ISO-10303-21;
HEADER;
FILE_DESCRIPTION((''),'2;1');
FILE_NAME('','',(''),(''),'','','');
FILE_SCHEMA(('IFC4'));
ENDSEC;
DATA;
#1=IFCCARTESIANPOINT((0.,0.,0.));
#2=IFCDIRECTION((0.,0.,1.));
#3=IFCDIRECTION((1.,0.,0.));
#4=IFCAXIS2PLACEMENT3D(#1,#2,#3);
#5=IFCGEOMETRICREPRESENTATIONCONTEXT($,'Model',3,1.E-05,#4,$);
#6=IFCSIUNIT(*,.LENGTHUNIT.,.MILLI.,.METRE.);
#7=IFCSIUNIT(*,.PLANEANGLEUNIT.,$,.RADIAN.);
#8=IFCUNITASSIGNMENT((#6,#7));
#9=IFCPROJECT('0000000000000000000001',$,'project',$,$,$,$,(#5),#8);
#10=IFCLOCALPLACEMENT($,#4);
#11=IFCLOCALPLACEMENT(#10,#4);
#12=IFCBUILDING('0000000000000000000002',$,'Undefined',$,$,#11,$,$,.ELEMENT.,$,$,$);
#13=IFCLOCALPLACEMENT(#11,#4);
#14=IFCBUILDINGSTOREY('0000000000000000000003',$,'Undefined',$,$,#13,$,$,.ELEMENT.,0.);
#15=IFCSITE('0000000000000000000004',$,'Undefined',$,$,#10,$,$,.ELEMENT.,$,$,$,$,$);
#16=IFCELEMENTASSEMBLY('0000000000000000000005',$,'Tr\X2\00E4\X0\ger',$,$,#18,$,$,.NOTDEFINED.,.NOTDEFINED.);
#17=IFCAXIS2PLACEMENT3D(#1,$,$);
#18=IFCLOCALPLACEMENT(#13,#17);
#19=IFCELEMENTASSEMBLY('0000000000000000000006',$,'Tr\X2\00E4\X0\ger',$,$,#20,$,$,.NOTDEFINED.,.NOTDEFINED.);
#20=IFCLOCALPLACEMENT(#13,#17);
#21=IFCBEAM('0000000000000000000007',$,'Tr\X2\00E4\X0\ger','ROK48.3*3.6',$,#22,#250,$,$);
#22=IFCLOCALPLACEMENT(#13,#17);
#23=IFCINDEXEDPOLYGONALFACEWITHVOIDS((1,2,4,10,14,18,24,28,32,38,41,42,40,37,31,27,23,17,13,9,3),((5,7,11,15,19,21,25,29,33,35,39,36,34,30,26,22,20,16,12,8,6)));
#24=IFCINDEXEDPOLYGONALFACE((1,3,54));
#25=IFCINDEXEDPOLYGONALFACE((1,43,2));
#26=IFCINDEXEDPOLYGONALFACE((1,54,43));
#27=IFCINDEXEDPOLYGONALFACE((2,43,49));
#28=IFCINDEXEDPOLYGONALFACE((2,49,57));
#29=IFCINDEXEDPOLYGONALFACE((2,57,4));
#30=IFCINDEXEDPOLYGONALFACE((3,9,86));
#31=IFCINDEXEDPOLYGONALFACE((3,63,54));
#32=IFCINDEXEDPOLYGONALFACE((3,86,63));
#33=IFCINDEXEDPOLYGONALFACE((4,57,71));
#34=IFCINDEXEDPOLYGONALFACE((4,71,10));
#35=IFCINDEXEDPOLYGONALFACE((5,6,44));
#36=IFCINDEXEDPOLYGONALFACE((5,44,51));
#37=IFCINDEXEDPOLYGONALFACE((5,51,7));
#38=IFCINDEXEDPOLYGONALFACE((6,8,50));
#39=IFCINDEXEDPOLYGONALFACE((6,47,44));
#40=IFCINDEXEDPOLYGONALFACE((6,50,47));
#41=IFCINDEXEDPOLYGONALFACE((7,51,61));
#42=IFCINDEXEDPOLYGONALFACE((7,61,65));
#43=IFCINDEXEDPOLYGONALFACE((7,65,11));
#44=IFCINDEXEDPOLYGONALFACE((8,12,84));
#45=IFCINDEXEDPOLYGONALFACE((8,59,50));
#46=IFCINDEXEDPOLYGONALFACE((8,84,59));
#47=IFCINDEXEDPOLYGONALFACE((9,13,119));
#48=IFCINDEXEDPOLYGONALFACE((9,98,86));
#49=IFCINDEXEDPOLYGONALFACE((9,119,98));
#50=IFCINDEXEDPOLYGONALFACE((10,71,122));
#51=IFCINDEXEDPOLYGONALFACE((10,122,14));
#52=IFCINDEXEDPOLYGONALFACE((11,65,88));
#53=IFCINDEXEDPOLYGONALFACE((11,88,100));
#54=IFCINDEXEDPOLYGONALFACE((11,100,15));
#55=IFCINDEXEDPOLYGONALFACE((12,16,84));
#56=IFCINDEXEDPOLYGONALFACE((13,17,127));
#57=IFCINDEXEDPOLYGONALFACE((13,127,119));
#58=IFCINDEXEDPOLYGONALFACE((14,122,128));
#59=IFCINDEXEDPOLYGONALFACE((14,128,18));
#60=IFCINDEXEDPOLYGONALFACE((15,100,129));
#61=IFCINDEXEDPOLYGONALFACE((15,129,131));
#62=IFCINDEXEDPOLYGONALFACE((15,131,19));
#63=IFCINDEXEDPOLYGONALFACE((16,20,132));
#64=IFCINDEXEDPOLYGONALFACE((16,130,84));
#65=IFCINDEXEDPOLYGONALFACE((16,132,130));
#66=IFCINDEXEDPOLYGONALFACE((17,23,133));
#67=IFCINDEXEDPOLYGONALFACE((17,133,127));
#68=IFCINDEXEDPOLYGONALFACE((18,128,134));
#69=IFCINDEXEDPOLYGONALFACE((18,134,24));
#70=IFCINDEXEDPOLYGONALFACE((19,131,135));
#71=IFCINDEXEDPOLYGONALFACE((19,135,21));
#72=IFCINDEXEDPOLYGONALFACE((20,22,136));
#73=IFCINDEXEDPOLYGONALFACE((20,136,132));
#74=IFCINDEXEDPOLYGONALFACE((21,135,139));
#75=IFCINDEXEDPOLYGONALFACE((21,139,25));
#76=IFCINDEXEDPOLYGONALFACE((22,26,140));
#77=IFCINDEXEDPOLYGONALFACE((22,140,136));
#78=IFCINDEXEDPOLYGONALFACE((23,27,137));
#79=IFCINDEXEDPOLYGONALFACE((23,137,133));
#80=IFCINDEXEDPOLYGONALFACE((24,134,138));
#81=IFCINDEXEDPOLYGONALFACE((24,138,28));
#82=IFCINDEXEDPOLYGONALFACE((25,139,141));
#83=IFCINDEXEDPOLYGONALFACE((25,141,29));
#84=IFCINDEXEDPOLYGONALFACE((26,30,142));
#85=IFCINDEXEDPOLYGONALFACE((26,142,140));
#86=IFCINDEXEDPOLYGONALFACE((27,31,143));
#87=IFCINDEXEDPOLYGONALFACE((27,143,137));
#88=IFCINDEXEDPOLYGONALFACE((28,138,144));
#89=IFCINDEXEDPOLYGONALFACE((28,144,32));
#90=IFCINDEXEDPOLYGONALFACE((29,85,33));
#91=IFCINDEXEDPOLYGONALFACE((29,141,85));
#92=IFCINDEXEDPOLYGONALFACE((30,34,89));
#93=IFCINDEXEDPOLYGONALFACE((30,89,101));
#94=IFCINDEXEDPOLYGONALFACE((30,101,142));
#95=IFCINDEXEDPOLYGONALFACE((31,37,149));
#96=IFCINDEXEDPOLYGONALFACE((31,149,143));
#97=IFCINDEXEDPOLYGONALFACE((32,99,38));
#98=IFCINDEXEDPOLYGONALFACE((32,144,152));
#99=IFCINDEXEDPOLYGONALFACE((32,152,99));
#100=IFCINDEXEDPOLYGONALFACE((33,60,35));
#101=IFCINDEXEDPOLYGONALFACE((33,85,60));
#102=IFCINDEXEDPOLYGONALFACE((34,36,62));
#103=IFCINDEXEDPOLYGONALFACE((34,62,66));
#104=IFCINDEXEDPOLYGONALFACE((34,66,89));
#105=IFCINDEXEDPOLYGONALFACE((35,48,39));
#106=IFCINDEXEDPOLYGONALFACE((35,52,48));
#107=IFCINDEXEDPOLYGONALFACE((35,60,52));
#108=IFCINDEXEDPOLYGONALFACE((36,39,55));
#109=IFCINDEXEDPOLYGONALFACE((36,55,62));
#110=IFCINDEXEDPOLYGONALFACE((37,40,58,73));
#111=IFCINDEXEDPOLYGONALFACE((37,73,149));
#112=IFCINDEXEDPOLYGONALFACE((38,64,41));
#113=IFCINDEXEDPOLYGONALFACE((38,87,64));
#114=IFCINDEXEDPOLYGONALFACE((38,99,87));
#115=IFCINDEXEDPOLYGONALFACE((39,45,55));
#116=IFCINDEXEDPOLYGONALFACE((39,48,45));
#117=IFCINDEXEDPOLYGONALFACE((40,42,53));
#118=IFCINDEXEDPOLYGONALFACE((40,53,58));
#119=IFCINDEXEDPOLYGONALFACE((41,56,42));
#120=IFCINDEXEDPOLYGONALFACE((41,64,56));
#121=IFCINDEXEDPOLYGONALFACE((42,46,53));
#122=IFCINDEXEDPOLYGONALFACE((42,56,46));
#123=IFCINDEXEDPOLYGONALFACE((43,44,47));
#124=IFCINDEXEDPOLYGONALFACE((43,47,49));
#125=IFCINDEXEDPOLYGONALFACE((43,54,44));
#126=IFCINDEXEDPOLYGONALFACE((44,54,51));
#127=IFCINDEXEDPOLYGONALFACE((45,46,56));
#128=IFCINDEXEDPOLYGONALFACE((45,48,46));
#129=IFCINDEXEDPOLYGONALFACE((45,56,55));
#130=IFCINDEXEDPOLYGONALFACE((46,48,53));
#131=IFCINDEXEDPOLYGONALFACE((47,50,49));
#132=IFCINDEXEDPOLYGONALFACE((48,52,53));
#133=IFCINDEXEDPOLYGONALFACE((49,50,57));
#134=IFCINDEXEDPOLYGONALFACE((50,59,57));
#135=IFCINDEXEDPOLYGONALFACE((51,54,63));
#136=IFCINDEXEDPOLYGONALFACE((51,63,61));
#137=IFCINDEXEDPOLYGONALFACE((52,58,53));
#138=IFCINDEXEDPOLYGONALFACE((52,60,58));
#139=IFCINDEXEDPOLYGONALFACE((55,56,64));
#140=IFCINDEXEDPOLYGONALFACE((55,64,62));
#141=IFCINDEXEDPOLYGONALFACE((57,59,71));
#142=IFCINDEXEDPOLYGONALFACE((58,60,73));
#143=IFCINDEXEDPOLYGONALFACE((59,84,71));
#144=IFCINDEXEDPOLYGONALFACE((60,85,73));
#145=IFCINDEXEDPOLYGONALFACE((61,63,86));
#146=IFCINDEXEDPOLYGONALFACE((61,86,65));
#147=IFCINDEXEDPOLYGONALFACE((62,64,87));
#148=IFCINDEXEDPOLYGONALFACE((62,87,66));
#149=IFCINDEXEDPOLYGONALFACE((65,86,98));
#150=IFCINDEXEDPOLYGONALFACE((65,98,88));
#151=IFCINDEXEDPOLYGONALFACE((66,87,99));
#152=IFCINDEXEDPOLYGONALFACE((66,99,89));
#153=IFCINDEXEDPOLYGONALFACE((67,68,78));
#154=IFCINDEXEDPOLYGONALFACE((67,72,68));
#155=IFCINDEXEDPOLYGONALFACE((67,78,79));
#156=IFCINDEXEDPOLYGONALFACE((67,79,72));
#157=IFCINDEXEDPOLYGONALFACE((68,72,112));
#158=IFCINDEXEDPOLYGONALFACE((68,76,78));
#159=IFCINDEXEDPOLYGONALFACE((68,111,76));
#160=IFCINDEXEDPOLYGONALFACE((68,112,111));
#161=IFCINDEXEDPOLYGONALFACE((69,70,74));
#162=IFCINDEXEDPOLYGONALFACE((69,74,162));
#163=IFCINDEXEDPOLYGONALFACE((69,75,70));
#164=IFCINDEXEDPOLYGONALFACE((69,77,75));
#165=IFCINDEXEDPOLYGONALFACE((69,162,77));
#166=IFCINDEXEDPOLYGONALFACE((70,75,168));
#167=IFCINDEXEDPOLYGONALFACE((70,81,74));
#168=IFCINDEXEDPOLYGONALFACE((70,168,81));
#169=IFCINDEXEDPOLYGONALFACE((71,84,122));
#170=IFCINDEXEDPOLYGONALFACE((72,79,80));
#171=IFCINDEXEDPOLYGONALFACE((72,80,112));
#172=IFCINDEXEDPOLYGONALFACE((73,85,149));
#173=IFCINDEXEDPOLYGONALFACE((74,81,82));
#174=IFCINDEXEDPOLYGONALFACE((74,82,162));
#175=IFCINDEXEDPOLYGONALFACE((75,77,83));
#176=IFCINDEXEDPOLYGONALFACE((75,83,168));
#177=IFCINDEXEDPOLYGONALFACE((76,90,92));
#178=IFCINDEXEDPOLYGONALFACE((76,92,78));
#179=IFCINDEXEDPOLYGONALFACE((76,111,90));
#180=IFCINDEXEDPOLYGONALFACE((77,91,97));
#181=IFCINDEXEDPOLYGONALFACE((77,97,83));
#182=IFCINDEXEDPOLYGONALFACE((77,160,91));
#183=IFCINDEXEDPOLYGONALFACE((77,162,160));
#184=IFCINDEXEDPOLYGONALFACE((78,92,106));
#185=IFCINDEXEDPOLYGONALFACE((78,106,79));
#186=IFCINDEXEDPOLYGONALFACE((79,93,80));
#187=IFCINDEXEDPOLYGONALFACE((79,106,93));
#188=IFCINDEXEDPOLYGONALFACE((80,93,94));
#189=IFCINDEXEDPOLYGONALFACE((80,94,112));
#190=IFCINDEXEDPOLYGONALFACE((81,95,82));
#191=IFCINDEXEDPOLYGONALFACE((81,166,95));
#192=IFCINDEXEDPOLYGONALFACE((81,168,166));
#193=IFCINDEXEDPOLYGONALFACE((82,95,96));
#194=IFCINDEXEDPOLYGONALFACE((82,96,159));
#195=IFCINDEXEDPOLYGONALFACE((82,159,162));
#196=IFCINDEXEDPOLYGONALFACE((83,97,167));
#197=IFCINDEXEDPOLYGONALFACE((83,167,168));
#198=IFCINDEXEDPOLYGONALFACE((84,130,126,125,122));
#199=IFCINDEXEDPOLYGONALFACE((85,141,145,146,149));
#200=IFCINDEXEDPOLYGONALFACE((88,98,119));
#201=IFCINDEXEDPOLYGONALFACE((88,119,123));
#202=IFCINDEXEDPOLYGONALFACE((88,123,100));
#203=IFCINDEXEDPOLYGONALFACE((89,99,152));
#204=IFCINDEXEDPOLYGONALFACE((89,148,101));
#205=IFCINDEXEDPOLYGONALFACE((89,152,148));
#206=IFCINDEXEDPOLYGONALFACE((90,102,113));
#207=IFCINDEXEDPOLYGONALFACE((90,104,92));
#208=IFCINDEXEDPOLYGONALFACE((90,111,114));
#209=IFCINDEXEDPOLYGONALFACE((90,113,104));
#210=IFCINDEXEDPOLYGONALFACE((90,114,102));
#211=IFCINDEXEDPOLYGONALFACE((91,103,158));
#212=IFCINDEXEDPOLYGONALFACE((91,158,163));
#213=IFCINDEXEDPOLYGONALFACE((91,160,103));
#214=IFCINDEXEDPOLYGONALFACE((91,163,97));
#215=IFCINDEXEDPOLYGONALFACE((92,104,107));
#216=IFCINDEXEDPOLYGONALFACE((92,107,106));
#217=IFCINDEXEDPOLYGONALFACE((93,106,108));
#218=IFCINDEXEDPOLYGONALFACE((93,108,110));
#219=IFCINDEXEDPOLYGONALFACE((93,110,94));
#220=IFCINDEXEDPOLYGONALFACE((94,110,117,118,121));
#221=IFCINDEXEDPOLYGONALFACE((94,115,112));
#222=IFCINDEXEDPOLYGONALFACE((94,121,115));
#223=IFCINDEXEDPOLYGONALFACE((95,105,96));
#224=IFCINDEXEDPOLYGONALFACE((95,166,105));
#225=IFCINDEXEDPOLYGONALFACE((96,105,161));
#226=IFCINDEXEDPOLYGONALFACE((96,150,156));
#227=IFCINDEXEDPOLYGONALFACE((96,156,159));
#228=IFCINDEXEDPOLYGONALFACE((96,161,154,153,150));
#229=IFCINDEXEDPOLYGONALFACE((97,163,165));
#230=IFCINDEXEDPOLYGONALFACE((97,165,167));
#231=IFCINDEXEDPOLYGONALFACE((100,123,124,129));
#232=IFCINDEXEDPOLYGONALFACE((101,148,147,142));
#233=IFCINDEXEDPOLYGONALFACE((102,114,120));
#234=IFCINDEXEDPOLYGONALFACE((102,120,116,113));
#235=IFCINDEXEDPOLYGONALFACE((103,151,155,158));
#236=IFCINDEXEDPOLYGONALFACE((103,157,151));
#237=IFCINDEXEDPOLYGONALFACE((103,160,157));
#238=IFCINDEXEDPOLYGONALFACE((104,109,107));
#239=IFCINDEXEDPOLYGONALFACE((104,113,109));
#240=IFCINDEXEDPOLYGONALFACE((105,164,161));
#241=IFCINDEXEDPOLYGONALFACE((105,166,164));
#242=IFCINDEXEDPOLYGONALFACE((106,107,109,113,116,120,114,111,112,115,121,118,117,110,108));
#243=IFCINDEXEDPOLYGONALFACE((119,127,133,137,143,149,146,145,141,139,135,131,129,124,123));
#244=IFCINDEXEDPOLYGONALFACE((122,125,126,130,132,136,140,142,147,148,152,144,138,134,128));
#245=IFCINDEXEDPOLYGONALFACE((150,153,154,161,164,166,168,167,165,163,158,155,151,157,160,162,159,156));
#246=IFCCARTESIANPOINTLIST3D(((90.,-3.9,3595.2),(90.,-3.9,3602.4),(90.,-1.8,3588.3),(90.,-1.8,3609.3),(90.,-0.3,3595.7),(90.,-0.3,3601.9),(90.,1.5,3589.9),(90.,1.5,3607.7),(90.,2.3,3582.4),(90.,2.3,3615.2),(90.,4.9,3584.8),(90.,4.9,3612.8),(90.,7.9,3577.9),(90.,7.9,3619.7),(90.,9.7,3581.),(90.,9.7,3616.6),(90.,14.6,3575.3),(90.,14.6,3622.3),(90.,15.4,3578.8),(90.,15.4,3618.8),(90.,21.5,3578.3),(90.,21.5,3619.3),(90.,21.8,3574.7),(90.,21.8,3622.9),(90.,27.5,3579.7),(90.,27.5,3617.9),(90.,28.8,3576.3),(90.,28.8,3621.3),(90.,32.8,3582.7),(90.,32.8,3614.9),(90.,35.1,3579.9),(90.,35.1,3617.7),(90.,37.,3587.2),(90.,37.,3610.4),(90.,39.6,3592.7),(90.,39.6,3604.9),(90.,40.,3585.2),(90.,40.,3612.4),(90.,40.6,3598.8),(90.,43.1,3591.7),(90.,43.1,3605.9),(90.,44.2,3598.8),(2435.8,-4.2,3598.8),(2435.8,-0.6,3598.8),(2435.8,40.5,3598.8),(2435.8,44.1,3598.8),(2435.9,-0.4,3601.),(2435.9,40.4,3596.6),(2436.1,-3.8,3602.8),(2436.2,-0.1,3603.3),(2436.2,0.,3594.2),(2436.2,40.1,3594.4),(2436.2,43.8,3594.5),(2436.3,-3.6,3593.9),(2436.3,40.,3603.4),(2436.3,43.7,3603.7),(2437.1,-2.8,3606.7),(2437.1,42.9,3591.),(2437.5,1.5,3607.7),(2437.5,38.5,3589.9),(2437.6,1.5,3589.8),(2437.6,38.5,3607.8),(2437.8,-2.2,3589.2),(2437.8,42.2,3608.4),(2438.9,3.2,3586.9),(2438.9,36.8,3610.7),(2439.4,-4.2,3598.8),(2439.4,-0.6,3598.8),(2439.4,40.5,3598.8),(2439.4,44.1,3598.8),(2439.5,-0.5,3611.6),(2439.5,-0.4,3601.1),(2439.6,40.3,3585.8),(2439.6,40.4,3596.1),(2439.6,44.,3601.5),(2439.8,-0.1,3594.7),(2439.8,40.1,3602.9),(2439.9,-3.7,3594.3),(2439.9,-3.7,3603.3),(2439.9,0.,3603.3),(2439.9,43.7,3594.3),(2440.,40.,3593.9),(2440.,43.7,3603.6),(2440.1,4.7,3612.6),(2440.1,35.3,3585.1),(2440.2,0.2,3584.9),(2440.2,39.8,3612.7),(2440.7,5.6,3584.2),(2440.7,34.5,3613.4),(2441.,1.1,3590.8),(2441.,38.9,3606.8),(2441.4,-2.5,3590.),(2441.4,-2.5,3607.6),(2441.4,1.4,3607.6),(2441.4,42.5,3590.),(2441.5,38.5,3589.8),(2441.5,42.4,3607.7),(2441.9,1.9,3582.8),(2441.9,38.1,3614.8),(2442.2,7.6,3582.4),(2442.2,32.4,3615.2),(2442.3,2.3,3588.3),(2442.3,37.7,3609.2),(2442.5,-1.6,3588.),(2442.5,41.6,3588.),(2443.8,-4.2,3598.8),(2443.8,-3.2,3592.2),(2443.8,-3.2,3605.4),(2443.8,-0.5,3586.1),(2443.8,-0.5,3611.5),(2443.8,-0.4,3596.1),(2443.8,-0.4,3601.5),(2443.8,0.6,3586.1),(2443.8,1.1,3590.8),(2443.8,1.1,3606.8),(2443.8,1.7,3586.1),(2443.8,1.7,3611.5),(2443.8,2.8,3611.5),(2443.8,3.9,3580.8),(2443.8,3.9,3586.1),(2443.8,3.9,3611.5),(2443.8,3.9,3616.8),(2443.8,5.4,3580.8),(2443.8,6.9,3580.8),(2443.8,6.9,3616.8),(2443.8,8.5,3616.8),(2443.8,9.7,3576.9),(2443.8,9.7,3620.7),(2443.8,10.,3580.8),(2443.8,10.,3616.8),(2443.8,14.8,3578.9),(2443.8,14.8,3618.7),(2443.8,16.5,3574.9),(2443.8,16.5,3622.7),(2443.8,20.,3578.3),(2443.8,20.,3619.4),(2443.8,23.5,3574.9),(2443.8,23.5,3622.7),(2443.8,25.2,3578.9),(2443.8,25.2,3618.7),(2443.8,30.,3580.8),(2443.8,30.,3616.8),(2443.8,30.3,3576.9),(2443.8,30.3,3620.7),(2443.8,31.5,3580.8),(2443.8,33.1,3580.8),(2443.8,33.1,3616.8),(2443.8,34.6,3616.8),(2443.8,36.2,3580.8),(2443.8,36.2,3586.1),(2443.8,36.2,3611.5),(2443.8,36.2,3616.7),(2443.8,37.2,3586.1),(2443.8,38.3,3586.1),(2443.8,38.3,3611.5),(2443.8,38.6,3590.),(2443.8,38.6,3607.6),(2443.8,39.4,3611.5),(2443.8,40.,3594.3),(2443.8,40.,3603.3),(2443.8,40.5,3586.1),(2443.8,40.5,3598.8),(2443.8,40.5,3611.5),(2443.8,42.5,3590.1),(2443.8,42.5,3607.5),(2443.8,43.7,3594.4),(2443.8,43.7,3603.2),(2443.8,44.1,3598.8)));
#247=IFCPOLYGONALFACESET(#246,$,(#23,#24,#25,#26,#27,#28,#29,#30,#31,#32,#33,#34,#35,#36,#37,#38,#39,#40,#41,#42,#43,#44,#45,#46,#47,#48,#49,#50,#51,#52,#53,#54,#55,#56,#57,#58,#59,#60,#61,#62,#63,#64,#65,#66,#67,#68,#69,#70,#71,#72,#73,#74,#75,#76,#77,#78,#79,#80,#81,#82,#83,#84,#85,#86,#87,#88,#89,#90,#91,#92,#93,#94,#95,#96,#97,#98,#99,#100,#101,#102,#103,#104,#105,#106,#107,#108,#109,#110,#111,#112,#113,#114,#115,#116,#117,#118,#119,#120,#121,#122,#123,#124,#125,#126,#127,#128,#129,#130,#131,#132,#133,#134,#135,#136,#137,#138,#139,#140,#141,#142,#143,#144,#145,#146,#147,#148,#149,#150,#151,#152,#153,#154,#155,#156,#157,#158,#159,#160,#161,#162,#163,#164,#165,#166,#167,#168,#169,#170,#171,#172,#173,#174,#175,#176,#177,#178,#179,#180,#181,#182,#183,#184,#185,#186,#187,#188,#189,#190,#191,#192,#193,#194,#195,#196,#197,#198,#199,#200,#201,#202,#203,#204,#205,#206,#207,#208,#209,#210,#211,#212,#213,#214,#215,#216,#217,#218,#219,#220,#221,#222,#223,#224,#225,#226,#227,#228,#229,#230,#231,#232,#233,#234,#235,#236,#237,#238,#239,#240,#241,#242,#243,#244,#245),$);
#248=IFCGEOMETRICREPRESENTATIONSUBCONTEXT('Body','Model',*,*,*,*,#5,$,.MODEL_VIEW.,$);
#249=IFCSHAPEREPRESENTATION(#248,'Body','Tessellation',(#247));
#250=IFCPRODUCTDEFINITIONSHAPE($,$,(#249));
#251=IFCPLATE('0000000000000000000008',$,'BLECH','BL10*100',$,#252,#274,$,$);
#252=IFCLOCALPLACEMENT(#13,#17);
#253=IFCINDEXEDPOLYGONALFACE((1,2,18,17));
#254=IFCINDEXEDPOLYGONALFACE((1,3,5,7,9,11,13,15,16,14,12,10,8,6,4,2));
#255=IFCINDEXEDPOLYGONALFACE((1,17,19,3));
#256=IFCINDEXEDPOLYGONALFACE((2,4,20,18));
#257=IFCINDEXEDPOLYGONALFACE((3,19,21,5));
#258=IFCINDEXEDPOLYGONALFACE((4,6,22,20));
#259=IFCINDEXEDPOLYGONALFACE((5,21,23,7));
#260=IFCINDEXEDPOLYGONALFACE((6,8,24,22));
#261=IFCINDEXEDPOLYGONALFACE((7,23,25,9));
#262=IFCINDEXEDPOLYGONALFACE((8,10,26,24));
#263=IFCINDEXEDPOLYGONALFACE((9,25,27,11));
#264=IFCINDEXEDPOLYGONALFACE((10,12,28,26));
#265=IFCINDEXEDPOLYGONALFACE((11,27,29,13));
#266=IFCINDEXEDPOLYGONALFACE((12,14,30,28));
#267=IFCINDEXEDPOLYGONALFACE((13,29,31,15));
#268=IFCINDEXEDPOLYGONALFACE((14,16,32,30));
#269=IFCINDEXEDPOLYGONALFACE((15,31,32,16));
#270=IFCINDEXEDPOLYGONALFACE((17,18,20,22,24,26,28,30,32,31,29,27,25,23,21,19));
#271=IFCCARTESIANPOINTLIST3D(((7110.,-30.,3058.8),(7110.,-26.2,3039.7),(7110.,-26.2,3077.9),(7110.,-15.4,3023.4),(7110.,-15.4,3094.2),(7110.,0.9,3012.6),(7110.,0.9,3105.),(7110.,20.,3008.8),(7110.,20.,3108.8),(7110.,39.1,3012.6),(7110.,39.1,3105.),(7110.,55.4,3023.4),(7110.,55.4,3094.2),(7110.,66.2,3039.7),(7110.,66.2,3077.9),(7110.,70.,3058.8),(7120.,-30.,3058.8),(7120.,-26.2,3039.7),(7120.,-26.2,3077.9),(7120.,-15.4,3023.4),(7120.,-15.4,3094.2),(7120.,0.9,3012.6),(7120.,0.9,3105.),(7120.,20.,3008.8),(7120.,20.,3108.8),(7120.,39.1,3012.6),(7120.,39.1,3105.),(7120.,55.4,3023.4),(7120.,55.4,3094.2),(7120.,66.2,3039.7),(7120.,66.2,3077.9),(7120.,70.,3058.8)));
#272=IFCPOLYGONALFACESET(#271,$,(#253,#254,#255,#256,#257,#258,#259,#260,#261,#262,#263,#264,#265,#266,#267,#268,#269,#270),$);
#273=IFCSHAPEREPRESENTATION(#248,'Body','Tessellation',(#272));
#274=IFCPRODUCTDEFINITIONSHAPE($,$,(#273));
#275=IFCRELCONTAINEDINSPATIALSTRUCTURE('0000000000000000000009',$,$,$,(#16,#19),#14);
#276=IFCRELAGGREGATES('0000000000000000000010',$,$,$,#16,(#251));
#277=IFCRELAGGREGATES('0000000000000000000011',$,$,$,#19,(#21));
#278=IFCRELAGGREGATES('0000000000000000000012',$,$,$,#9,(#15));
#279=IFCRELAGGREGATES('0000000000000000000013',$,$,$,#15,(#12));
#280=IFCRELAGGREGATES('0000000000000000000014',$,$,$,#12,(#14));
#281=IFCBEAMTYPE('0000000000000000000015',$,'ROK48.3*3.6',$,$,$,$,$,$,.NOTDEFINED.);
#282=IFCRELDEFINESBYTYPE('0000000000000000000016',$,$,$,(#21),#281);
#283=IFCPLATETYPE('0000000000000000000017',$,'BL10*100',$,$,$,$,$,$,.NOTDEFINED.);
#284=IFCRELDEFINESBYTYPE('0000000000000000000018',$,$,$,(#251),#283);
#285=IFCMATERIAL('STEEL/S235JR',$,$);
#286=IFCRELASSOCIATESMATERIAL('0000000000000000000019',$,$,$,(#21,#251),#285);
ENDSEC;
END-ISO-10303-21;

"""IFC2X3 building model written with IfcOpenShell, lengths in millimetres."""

from ifc_helpers import new_model, si_unit, frame, origin_with_axes, origin_2d_with_axis, place, context, subcontext, project, spatial, polyline, hollow_circle, outline, extrude, boolean, material, type_object, element, aggregate, save


model = new_model("IFC2X3")

# Units and contexts
model_context = context("Model", 3, precision=1e-05, world=origin_with_axes())
body_context = subcontext(model_context, "Body", "Model", "MODEL_VIEW")
ifc_project = project(units=[si_unit("LENGTHUNIT", "METRE", prefix="MILLI"), si_unit("PLANEANGLEUNIT", "RADIAN")], contexts=[model_context])

# Site, building, storey
site_placement = place(None, origin_with_axes())
site = spatial("IfcSite", under=ifc_project, at=site_placement, Name="Undefined", CompositionType="ELEMENT")
building_placement = place(site_placement, origin_with_axes())
building = spatial("IfcBuilding", under=site, at=building_placement, Name="Undefined", CompositionType="ELEMENT")
storey_placement = place(building_placement, origin_with_axes())
storey = spatial("IfcBuildingStorey", under=building, at=storey_placement, Name="Undefined", CompositionType="ELEMENT", Elevation=0.0)

# Element assembly
assembly_1_placement = place(storey_placement, origin_with_axes())
assembly_1 = element("IfcElementAssembly", 1, at=assembly_1_placement, inside=storey, Name="Träger", AssemblyPlace="NOTDEFINED", PredefinedType="NOTDEFINED")
ifc_material = material(Name="STEEL/S235JR")
beam_type = type_object("IfcBeamType", Name="ROK48.3*3.6", PredefinedType="NOTDEFINED")

# Element assembly, beam
assembly_2_placement = place(storey_placement, origin_with_axes())
assembly_2 = element("IfcElementAssembly", 2, at=assembly_2_placement, inside=storey, Name="Träger", AssemblyPlace="NOTDEFINED", PredefinedType="NOTDEFINED")
beam_1_placement = place(assembly_2_placement, frame((2443.8, 20.0, 3598.8), z_axis=(0.0, 0.0, 1.0), x_axis=(-1.0, 0.0, 0.0)))
beam_1 = element("IfcBeam", 3, at=beam_1_placement, type_object=beam_type, material=ifc_material, Name="Träger", Description="ROK48.3*3.6", context=body_context, shape_type="CSG", body=[
    boolean("DIFFERENCE", extrude(hollow_circle(Radius=24.1, WallThickness=3.6, at=origin_2d_with_axis()), frame((2353.8, 0.0, 0.0), z_axis=(-1.0, 0.0, 0.0), x_axis=(0.0, -1.0, 0.0)), (0.0, 0.0, 1.0), 2353.8), extrude(hollow_circle(Radius=24.1, WallThickness=3.6, at=origin_2d_with_axis()), frame((-16.2, -90.0, 0.0), z_axis=(0.000346, 1.0, -0.000024), x_axis=(1.0, -0.000346, 0.0)), (0.0, 0.0, 1.0), 146.2)),
])

# Plate
plate_type_1 = type_object("IfcPlateType", Name="BL10*100", PredefinedType="NOTDEFINED")
plate_1_placement = place(assembly_1_placement, frame((7115.0, 70.0, 3108.8), z_axis=(1.0, 0.0, 0.0), x_axis=(0.0, -1.0, 0.0)))
plate_1 = element("IfcPlate", 4, at=plate_1_placement, type_object=plate_type_1, material=ifc_material, Name="BLECH", Description="BL10*100", context=body_context, shape_type="SweptSolid", body=[
    extrude(outline(polyline([(0.0, 50.0), (3.8, 30.9), (14.6, 14.6), (30.9, 3.8), (50.0, 0.0), (50.0, 0.0), (69.1, 3.8), (85.4, 14.6), (96.2, 30.9), (100.0, 50.0), (100.0, 50.0), (96.2, 69.1), (85.4, 85.4), (69.1, 96.2), (50.0, 100.0), (50.0, 100.0), (30.9, 96.2), (14.6, 85.4), (3.8, 69.1), (0.0, 50.0), (0.0, 50.0)])), frame((0.0, 0.0, -5.0), z_axis=(0.0, 0.0, 1.0), x_axis=(1.0, 0.0, 0.0)), (0.0, 0.0, 1.0), 10.0),
])
aggregate(assembly_1, [plate_1])
aggregate(assembly_2, [beam_1])

save(model, "model.ifc")
